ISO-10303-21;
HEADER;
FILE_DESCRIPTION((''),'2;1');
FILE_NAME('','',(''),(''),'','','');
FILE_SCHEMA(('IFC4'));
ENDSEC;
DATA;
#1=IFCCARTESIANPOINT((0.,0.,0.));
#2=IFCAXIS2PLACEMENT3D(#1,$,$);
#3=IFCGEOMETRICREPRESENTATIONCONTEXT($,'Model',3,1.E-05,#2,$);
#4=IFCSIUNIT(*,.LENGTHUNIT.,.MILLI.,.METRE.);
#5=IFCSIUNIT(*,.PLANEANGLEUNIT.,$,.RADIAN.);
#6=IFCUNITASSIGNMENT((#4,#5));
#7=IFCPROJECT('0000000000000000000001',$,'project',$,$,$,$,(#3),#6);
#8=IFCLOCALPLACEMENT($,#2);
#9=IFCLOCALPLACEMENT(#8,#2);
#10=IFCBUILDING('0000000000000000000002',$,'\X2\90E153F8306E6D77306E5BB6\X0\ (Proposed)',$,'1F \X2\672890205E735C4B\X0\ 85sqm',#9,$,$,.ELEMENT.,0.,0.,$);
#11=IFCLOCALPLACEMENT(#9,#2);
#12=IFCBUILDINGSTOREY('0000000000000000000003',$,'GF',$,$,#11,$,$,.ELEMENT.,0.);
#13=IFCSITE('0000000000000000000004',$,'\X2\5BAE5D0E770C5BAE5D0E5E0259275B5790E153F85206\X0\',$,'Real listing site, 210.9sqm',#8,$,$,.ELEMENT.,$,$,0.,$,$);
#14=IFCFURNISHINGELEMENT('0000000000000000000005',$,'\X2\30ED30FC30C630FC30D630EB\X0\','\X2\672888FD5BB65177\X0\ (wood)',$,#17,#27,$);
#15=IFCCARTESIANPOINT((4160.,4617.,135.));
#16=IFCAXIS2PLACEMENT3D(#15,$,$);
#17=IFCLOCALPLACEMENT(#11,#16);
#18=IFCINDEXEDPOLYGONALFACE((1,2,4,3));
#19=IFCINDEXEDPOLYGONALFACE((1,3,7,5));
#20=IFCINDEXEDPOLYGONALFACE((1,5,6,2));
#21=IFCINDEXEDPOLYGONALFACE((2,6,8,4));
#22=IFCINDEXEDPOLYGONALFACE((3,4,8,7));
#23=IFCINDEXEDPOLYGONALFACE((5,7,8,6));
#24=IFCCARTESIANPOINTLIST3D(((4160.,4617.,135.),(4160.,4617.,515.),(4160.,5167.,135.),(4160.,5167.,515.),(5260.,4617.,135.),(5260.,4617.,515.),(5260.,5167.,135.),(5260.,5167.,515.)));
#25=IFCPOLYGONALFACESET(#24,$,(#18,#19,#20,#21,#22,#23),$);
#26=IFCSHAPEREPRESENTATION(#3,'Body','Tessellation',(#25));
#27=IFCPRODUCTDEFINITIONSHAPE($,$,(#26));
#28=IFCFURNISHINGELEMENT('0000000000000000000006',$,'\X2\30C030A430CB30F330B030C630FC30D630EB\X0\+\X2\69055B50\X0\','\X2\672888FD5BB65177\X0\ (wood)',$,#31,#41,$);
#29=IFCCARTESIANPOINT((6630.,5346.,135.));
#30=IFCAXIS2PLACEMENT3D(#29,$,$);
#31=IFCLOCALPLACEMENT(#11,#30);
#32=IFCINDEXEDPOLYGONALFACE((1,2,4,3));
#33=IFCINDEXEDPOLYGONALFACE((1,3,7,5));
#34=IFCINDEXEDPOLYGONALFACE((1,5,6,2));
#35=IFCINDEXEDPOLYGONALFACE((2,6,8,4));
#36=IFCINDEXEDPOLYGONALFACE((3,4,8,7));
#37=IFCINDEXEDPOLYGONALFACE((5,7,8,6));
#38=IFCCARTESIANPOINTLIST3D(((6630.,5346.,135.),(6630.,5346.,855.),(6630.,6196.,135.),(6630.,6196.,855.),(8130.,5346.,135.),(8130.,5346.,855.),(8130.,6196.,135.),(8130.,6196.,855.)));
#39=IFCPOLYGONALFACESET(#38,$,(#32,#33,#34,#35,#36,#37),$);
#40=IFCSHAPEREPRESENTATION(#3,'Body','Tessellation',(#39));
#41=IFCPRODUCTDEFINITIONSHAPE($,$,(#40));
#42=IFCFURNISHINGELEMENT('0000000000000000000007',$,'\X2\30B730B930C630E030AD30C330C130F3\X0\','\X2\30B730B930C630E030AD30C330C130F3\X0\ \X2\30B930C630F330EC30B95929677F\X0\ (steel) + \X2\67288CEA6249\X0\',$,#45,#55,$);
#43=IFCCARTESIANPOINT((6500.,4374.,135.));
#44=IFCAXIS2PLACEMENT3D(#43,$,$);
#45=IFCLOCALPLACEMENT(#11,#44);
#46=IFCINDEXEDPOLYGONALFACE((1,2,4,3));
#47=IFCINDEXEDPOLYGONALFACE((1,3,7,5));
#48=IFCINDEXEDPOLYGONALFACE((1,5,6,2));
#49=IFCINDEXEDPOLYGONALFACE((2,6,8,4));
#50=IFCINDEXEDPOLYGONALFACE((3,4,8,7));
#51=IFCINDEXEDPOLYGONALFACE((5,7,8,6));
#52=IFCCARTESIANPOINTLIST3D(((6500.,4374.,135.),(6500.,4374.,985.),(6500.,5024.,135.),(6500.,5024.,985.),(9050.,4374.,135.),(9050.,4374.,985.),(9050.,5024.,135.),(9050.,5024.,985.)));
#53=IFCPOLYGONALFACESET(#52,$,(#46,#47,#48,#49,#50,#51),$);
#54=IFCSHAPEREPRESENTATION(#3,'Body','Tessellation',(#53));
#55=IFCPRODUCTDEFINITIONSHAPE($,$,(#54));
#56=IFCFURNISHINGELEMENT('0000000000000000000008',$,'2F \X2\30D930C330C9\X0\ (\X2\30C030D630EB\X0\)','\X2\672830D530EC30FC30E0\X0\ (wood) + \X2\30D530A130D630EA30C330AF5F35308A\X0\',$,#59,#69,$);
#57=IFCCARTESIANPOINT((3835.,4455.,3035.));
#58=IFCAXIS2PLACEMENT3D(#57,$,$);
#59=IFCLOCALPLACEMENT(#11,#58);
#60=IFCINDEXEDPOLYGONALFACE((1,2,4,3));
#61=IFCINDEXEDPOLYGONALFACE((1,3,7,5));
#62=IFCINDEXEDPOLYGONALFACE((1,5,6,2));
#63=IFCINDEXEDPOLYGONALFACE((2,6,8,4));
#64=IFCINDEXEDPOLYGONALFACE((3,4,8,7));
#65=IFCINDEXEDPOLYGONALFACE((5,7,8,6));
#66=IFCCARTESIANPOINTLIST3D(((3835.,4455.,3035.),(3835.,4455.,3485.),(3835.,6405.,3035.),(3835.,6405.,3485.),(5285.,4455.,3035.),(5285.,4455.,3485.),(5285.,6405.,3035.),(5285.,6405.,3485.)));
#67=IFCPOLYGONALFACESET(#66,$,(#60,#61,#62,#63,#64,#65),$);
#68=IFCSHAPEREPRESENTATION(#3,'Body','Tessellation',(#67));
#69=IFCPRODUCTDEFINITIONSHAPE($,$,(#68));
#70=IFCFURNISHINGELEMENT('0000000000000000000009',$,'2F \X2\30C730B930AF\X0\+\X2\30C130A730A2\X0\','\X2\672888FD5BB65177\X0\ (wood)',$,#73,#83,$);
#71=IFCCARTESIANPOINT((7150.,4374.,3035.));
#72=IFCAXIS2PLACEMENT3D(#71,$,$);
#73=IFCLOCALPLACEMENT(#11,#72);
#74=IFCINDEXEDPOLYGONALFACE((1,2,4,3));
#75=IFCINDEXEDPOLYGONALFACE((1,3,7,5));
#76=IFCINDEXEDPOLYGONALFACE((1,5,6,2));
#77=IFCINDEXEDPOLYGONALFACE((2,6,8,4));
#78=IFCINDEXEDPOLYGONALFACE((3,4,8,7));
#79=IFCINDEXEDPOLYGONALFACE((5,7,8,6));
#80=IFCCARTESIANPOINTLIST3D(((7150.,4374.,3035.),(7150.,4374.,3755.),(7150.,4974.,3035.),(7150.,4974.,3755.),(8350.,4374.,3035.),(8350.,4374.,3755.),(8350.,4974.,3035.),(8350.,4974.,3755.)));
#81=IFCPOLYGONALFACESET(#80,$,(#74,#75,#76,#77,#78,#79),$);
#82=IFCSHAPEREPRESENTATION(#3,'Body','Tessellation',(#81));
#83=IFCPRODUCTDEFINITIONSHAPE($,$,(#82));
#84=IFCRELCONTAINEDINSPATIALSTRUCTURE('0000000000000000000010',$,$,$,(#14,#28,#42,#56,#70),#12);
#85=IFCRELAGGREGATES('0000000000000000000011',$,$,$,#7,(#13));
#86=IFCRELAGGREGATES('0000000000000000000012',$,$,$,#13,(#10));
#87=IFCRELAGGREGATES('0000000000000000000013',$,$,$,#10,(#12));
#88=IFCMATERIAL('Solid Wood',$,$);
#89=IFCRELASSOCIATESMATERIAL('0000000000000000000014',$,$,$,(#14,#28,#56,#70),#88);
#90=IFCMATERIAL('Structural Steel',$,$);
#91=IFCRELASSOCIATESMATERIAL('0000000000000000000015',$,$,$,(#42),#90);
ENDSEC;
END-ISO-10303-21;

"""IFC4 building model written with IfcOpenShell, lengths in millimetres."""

from ifc_helpers import new_model, si_unit, frame, frame_2d, origin, place, context, project, spatial, rectangle, extrude, material, element, save


model = new_model("IFC4")

# Units and contexts
model_context = context("Model", 3, precision=1e-05, world=origin())
ifc_project = project(units=[si_unit("LENGTHUNIT", "METRE", prefix="MILLI"), si_unit("PLANEANGLEUNIT", "RADIAN")], contexts=[model_context])

# Site, building, storey
site_placement = place(None, origin())
site = spatial("IfcSite", under=ifc_project, at=site_placement, Name="宮崎県宮崎市大字郡司分", ObjectType="Real listing site, 210.9sqm", CompositionType="ELEMENT", RefElevation=0.0)
building_placement = place(site_placement, origin())
building = spatial("IfcBuilding", under=site, at=building_placement, Name="郡司の海の家 (Proposed)", ObjectType="1F 木造平屋 85sqm", CompositionType="ELEMENT", ElevationOfRefHeight=0.0, ElevationOfTerrain=0.0)
storey_placement = place(building_placement, origin())
storey = spatial("IfcBuildingStorey", under=building, at=storey_placement, Name="GF", CompositionType="ELEMENT", Elevation=0.0)

# Shared definitions
ifc_material_1 = material(Name="Solid Wood")

# Shared definitions
ifc_material_2 = material(Name="Structural Steel")

# Furnishing elements
furnishing_1_placement = place(storey_placement, frame((4160.0, 4617.0, 135.0)))
element("IfcFurnishingElement", 1, at=furnishing_1_placement, inside=storey, material=ifc_material_1, Name="ローテーブル", Description="木製家具 (wood)", context=model_context, shape_type="SweptSolid", body=[
    extrude(rectangle(XDim=1100.0, YDim=550.0, at=frame_2d((550.0, 275.0))), frame((4160.0, 4617.0, 135.0)), (0.0, 0.0, 1.0), 380.0),
])
furnishing_2_placement = place(storey_placement, frame((6630.0, 5346.0, 135.0)))
element("IfcFurnishingElement", 2, at=furnishing_2_placement, inside=storey, material=ifc_material_1, Name="ダイニングテーブル+椅子", Description="木製家具 (wood)", context=model_context, shape_type="SweptSolid", body=[
    extrude(rectangle(XDim=1500.0, YDim=850.0, at=frame_2d((750.0, 425.0))), frame((6630.0, 5346.0, 135.0)), (0.0, 0.0, 1.0), 720.0),
])
furnishing_3_placement = place(storey_placement, frame((6500.0, 4374.0, 135.0)))
element("IfcFurnishingElement", 3, at=furnishing_3_placement, inside=storey, material=ifc_material_2, Name="システムキッチン", Description="システムキッチン ステンレス天板 (steel) + 木質扉", context=model_context, shape_type="SweptSolid", body=[
    extrude(rectangle(XDim=2550.0, YDim=650.0, at=frame_2d((1275.0, 325.0))), frame((6500.0, 4374.0, 135.0)), (0.0, 0.0, 1.0), 850.0),
])
furnishing_4_placement = place(storey_placement, frame((3835.0, 4455.0, 3035.0)))
element("IfcFurnishingElement", 4, at=furnishing_4_placement, inside=storey, material=ifc_material_1, Name="2F ベッド (ダブル)", Description="木フレーム (wood) + ファブリック張り", context=model_context, shape_type="SweptSolid", body=[
    extrude(rectangle(XDim=1450.0, YDim=1950.0, at=frame_2d((725.0, 975.0))), frame((3835.0, 4455.0, 3035.0)), (0.0, 0.0, 1.0), 450.0),
])
furnishing_5_placement = place(storey_placement, frame((7150.0, 4374.0, 3035.0)))
element("IfcFurnishingElement", 5, at=furnishing_5_placement, inside=storey, material=ifc_material_1, Name="2F デスク+チェア", Description="木製家具 (wood)", context=model_context, shape_type="SweptSolid", body=[
    extrude(rectangle(XDim=1200.0, YDim=600.0, at=frame_2d((600.0, 300.0))), frame((7150.0, 4374.0, 3035.0)), (0.0, 0.0, 1.0), 720.0),
])

save(model, "model.ifc")
